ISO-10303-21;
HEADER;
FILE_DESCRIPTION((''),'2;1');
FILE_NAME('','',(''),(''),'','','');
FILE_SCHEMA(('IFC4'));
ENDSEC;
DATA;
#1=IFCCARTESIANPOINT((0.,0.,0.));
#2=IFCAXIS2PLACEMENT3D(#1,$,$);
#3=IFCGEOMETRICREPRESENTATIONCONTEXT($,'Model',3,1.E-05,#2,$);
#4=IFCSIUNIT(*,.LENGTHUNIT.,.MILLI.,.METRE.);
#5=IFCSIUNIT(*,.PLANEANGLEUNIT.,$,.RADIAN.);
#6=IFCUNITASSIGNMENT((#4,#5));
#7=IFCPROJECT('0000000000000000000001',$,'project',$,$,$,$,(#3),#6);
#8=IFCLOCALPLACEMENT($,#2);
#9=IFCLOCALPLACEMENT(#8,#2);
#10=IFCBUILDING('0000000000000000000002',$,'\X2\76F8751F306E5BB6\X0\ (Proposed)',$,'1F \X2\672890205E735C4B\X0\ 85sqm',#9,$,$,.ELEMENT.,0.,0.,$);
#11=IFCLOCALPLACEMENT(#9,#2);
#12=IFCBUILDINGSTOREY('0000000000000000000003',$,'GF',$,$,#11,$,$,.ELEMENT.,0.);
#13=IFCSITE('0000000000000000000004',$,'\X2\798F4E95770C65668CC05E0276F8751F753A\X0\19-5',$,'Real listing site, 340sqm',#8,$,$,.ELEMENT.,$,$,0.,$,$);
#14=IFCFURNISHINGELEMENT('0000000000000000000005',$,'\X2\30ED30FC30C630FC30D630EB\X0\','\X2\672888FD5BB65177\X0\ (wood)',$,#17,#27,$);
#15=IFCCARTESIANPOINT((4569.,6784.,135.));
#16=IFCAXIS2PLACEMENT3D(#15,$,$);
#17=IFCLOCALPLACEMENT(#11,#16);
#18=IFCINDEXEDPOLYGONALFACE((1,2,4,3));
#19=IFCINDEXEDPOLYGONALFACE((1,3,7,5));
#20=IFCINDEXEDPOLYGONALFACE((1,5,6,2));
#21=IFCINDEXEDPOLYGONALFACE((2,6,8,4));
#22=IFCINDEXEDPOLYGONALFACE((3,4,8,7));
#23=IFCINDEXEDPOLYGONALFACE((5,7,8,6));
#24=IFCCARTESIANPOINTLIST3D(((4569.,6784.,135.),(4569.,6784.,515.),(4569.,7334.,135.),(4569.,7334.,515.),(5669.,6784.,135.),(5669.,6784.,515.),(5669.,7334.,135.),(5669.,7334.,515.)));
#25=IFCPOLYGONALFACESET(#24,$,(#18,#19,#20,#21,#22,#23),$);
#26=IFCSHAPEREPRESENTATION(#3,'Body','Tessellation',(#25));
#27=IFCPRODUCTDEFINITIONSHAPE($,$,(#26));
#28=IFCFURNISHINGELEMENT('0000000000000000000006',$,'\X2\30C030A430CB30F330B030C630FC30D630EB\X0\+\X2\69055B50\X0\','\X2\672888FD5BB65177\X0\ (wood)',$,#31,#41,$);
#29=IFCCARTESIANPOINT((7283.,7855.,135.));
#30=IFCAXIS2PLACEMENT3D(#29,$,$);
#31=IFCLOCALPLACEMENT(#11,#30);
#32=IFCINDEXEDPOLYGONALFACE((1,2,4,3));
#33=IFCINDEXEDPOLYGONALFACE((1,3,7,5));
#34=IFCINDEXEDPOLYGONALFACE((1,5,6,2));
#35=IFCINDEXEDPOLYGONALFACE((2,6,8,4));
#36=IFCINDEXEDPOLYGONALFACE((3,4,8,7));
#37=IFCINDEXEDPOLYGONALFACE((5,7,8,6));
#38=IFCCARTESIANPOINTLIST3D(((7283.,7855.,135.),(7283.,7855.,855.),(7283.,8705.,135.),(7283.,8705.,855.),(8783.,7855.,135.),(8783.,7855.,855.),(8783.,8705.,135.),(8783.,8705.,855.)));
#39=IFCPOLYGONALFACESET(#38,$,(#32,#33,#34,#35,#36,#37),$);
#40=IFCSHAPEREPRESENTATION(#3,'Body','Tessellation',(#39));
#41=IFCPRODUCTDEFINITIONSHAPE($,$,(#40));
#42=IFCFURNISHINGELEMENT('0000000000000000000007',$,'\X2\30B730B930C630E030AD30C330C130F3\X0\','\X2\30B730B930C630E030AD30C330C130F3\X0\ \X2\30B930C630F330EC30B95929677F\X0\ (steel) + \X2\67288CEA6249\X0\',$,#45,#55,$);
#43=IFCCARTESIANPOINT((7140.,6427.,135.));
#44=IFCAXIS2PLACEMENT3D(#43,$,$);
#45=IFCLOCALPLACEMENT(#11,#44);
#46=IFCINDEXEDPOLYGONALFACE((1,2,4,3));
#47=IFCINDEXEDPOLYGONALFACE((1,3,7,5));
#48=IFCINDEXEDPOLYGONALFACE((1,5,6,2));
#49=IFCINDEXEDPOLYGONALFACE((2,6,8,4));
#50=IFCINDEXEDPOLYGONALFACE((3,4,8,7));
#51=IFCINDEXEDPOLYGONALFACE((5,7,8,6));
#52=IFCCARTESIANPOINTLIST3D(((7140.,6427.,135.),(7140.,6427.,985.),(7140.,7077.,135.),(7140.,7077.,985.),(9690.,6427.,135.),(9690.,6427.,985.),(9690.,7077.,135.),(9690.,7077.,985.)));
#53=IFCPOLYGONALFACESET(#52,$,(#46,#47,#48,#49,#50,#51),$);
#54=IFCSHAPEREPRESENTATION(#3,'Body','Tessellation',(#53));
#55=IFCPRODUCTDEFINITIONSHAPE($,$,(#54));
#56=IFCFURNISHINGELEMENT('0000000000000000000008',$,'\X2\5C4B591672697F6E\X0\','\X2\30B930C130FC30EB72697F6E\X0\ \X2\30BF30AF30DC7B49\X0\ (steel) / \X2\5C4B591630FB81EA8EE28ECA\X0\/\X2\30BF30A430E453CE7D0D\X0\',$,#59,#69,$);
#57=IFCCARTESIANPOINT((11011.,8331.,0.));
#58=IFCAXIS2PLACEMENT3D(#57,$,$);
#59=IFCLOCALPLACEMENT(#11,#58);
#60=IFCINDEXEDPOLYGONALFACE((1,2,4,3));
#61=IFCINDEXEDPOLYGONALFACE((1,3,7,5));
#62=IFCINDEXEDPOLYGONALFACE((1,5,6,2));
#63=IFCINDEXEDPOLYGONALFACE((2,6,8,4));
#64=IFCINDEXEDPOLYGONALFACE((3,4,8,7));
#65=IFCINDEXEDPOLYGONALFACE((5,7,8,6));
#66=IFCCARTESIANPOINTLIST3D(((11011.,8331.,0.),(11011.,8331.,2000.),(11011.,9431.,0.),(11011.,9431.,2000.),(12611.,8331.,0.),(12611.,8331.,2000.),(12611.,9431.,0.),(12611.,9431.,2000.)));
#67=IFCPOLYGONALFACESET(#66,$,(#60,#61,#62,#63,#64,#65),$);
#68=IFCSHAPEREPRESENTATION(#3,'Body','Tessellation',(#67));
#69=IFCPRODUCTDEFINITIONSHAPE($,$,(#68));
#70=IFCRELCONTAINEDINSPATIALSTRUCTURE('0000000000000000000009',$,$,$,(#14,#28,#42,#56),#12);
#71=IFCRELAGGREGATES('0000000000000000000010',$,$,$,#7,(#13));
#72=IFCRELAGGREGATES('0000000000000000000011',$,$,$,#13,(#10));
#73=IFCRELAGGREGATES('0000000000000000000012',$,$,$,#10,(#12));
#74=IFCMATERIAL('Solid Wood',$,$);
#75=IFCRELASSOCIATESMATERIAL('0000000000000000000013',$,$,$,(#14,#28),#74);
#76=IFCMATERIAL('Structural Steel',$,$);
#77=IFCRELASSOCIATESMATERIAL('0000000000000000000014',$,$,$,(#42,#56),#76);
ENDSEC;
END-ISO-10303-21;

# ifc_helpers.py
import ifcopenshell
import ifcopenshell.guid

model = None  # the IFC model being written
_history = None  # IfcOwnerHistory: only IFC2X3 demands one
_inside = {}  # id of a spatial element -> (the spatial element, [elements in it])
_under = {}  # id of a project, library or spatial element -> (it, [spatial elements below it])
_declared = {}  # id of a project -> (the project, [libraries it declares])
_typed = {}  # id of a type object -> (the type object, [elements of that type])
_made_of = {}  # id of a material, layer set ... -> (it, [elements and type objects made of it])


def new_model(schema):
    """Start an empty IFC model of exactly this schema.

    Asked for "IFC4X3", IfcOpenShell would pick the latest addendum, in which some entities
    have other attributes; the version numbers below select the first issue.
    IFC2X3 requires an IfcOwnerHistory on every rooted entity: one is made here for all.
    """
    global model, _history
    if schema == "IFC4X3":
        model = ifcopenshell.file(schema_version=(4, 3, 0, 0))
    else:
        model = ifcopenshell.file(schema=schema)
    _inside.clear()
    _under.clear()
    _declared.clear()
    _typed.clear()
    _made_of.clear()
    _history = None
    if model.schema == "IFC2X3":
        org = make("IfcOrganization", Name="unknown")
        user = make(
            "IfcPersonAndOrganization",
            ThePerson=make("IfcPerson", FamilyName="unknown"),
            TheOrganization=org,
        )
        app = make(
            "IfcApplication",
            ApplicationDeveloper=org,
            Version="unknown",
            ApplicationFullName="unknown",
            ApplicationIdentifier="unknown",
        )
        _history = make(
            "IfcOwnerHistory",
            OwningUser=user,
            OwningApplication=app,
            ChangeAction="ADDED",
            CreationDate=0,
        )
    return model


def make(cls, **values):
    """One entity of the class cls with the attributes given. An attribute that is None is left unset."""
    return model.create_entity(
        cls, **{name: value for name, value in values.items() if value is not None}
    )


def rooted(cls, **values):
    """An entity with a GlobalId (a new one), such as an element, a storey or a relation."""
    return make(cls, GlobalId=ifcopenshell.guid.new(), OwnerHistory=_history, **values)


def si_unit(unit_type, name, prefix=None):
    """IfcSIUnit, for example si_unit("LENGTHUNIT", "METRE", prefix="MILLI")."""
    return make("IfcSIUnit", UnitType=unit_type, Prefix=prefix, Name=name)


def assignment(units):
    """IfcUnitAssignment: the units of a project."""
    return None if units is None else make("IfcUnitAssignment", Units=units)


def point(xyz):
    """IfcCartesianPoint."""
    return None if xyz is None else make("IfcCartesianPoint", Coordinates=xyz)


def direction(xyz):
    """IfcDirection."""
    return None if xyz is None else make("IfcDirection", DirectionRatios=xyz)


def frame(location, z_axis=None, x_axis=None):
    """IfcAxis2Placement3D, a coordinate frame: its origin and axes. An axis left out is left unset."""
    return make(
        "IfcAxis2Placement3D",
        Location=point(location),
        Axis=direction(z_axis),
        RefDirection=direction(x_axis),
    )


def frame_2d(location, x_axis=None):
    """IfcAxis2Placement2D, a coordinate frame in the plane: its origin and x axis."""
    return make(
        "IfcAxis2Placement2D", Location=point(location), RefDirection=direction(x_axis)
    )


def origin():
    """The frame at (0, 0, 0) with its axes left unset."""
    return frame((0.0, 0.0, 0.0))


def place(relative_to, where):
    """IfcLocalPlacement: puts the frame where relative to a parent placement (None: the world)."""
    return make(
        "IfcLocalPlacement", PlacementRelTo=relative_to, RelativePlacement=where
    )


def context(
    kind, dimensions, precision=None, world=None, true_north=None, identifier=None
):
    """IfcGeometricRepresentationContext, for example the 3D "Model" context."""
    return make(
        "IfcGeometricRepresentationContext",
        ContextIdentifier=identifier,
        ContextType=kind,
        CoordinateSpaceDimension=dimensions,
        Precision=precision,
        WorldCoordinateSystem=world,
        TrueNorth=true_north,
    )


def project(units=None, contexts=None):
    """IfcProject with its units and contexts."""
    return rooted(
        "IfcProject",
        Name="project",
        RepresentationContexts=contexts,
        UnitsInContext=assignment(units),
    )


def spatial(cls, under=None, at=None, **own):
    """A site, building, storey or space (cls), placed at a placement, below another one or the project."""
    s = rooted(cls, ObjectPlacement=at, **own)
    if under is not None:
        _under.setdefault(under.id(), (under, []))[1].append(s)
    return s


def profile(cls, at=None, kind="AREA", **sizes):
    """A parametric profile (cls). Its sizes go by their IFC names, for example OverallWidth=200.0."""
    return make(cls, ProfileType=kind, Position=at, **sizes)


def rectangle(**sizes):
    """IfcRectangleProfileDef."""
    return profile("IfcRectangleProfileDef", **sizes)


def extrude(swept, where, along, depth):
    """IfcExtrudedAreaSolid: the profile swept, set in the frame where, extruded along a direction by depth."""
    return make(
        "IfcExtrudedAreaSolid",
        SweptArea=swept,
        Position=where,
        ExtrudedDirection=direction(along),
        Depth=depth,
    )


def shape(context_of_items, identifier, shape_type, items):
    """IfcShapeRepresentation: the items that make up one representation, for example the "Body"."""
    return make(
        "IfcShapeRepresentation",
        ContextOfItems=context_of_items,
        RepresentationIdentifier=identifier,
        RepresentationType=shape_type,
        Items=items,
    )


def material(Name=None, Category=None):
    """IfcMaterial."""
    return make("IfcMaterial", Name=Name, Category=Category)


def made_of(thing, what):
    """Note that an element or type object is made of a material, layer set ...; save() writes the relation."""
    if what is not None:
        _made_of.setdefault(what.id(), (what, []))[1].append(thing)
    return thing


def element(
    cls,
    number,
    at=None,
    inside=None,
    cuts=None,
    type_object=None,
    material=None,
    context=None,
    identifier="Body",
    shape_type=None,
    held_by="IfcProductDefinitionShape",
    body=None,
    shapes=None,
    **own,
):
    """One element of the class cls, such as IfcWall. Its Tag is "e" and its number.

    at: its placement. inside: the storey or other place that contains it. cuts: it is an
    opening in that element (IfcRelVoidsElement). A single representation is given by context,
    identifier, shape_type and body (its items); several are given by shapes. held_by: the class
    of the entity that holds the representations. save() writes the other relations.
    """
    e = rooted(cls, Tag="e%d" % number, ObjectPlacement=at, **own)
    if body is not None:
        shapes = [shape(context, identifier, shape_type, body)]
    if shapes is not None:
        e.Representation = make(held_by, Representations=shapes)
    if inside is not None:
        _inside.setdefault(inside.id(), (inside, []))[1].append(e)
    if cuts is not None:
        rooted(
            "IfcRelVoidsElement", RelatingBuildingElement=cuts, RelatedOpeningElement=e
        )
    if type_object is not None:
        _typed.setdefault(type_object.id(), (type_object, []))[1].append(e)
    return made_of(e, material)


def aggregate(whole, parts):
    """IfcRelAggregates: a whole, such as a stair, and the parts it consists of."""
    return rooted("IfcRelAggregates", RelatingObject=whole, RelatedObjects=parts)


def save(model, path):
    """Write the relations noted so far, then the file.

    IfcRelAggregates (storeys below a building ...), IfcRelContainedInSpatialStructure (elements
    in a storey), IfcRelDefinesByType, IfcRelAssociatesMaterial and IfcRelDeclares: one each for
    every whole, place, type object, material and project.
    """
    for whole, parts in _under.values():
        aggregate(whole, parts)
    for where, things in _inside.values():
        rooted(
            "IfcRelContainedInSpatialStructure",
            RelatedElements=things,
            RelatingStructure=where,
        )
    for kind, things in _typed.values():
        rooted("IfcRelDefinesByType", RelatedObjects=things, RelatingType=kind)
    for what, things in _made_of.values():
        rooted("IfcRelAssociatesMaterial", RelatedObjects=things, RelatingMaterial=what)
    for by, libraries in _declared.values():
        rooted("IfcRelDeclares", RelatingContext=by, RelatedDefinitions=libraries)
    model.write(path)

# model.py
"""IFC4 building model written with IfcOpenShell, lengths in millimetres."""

from ifc_helpers import new_model, si_unit, frame, frame_2d, origin, place, context, project, spatial, rectangle, extrude, material, element, save


model = new_model("IFC4")

# Units and contexts
model_context = context("Model", 3, precision=1e-05, world=origin())
ifc_project = project(units=[si_unit("LENGTHUNIT", "METRE", prefix="MILLI"), si_unit("PLANEANGLEUNIT", "RADIAN")], contexts=[model_context])

# Site, building, storey
site_placement = place(None, origin())
site = spatial("IfcSite", under=ifc_project, at=site_placement, Name="福井県敦賀市相生町19-5", ObjectType="Real listing site, 340sqm", CompositionType="ELEMENT", RefElevation=0.0)
building_placement = place(site_placement, origin())
building = spatial("IfcBuilding", under=site, at=building_placement, Name="相生の家 (Proposed)", ObjectType="1F 木造平屋 85sqm", CompositionType="ELEMENT", ElevationOfRefHeight=0.0, ElevationOfTerrain=0.0)
storey_placement = place(building_placement, origin())
storey = spatial("IfcBuildingStorey", under=building, at=storey_placement, Name="GF", CompositionType="ELEMENT", Elevation=0.0)

# Shared definitions
ifc_material_1 = material(Name="Solid Wood")

# Shared definitions
ifc_material_2 = material(Name="Structural Steel")

# Furnishing elements
furnishing_1_placement = place(storey_placement, frame((4569.0, 6784.0, 135.0)))
element("IfcFurnishingElement", 1, at=furnishing_1_placement, inside=storey, material=ifc_material_1, Name="ローテーブル", Description="木製家具 (wood)", context=model_context, shape_type="SweptSolid", body=[
    extrude(rectangle(XDim=1100.0, YDim=550.0, at=frame_2d((550.0, 275.0))), frame((4569.0, 6784.0, 135.0)), (0.0, 0.0, 1.0), 380.0),
])
furnishing_2_placement = place(storey_placement, frame((7283.0, 7855.0, 135.0)))
element("IfcFurnishingElement", 2, at=furnishing_2_placement, inside=storey, material=ifc_material_1, Name="ダイニングテーブル+椅子", Description="木製家具 (wood)", context=model_context, shape_type="SweptSolid", body=[
    extrude(rectangle(XDim=1500.0, YDim=850.0, at=frame_2d((750.0, 425.0))), frame((7283.0, 7855.0, 135.0)), (0.0, 0.0, 1.0), 720.0),
])
furnishing_3_placement = place(storey_placement, frame((7140.0, 6427.0, 135.0)))
element("IfcFurnishingElement", 3, at=furnishing_3_placement, inside=storey, material=ifc_material_2, Name="システムキッチン", Description="システムキッチン ステンレス天板 (steel) + 木質扉", context=model_context, shape_type="SweptSolid", body=[
    extrude(rectangle(XDim=2550.0, YDim=650.0, at=frame_2d((1275.0, 325.0))), frame((7140.0, 6427.0, 135.0)), (0.0, 0.0, 1.0), 850.0),
])
furnishing_4_placement = place(storey_placement, frame((11011.0, 8331.0, 0.0)))
element("IfcFurnishingElement", 4, at=furnishing_4_placement, inside=storey, material=ifc_material_2, Name="屋外物置", Description="スチール物置 タクボ等 (steel) / 屋外・自転車/タイヤ収納", context=model_context, shape_type="SweptSolid", body=[
    extrude(rectangle(XDim=1600.0, YDim=1100.0, at=frame_2d((800.0, 550.0))), frame((11011.0, 8331.0, 0.0)), (0.0, 0.0, 1.0), 2000.0),
])

save(model, "model.ifc")
